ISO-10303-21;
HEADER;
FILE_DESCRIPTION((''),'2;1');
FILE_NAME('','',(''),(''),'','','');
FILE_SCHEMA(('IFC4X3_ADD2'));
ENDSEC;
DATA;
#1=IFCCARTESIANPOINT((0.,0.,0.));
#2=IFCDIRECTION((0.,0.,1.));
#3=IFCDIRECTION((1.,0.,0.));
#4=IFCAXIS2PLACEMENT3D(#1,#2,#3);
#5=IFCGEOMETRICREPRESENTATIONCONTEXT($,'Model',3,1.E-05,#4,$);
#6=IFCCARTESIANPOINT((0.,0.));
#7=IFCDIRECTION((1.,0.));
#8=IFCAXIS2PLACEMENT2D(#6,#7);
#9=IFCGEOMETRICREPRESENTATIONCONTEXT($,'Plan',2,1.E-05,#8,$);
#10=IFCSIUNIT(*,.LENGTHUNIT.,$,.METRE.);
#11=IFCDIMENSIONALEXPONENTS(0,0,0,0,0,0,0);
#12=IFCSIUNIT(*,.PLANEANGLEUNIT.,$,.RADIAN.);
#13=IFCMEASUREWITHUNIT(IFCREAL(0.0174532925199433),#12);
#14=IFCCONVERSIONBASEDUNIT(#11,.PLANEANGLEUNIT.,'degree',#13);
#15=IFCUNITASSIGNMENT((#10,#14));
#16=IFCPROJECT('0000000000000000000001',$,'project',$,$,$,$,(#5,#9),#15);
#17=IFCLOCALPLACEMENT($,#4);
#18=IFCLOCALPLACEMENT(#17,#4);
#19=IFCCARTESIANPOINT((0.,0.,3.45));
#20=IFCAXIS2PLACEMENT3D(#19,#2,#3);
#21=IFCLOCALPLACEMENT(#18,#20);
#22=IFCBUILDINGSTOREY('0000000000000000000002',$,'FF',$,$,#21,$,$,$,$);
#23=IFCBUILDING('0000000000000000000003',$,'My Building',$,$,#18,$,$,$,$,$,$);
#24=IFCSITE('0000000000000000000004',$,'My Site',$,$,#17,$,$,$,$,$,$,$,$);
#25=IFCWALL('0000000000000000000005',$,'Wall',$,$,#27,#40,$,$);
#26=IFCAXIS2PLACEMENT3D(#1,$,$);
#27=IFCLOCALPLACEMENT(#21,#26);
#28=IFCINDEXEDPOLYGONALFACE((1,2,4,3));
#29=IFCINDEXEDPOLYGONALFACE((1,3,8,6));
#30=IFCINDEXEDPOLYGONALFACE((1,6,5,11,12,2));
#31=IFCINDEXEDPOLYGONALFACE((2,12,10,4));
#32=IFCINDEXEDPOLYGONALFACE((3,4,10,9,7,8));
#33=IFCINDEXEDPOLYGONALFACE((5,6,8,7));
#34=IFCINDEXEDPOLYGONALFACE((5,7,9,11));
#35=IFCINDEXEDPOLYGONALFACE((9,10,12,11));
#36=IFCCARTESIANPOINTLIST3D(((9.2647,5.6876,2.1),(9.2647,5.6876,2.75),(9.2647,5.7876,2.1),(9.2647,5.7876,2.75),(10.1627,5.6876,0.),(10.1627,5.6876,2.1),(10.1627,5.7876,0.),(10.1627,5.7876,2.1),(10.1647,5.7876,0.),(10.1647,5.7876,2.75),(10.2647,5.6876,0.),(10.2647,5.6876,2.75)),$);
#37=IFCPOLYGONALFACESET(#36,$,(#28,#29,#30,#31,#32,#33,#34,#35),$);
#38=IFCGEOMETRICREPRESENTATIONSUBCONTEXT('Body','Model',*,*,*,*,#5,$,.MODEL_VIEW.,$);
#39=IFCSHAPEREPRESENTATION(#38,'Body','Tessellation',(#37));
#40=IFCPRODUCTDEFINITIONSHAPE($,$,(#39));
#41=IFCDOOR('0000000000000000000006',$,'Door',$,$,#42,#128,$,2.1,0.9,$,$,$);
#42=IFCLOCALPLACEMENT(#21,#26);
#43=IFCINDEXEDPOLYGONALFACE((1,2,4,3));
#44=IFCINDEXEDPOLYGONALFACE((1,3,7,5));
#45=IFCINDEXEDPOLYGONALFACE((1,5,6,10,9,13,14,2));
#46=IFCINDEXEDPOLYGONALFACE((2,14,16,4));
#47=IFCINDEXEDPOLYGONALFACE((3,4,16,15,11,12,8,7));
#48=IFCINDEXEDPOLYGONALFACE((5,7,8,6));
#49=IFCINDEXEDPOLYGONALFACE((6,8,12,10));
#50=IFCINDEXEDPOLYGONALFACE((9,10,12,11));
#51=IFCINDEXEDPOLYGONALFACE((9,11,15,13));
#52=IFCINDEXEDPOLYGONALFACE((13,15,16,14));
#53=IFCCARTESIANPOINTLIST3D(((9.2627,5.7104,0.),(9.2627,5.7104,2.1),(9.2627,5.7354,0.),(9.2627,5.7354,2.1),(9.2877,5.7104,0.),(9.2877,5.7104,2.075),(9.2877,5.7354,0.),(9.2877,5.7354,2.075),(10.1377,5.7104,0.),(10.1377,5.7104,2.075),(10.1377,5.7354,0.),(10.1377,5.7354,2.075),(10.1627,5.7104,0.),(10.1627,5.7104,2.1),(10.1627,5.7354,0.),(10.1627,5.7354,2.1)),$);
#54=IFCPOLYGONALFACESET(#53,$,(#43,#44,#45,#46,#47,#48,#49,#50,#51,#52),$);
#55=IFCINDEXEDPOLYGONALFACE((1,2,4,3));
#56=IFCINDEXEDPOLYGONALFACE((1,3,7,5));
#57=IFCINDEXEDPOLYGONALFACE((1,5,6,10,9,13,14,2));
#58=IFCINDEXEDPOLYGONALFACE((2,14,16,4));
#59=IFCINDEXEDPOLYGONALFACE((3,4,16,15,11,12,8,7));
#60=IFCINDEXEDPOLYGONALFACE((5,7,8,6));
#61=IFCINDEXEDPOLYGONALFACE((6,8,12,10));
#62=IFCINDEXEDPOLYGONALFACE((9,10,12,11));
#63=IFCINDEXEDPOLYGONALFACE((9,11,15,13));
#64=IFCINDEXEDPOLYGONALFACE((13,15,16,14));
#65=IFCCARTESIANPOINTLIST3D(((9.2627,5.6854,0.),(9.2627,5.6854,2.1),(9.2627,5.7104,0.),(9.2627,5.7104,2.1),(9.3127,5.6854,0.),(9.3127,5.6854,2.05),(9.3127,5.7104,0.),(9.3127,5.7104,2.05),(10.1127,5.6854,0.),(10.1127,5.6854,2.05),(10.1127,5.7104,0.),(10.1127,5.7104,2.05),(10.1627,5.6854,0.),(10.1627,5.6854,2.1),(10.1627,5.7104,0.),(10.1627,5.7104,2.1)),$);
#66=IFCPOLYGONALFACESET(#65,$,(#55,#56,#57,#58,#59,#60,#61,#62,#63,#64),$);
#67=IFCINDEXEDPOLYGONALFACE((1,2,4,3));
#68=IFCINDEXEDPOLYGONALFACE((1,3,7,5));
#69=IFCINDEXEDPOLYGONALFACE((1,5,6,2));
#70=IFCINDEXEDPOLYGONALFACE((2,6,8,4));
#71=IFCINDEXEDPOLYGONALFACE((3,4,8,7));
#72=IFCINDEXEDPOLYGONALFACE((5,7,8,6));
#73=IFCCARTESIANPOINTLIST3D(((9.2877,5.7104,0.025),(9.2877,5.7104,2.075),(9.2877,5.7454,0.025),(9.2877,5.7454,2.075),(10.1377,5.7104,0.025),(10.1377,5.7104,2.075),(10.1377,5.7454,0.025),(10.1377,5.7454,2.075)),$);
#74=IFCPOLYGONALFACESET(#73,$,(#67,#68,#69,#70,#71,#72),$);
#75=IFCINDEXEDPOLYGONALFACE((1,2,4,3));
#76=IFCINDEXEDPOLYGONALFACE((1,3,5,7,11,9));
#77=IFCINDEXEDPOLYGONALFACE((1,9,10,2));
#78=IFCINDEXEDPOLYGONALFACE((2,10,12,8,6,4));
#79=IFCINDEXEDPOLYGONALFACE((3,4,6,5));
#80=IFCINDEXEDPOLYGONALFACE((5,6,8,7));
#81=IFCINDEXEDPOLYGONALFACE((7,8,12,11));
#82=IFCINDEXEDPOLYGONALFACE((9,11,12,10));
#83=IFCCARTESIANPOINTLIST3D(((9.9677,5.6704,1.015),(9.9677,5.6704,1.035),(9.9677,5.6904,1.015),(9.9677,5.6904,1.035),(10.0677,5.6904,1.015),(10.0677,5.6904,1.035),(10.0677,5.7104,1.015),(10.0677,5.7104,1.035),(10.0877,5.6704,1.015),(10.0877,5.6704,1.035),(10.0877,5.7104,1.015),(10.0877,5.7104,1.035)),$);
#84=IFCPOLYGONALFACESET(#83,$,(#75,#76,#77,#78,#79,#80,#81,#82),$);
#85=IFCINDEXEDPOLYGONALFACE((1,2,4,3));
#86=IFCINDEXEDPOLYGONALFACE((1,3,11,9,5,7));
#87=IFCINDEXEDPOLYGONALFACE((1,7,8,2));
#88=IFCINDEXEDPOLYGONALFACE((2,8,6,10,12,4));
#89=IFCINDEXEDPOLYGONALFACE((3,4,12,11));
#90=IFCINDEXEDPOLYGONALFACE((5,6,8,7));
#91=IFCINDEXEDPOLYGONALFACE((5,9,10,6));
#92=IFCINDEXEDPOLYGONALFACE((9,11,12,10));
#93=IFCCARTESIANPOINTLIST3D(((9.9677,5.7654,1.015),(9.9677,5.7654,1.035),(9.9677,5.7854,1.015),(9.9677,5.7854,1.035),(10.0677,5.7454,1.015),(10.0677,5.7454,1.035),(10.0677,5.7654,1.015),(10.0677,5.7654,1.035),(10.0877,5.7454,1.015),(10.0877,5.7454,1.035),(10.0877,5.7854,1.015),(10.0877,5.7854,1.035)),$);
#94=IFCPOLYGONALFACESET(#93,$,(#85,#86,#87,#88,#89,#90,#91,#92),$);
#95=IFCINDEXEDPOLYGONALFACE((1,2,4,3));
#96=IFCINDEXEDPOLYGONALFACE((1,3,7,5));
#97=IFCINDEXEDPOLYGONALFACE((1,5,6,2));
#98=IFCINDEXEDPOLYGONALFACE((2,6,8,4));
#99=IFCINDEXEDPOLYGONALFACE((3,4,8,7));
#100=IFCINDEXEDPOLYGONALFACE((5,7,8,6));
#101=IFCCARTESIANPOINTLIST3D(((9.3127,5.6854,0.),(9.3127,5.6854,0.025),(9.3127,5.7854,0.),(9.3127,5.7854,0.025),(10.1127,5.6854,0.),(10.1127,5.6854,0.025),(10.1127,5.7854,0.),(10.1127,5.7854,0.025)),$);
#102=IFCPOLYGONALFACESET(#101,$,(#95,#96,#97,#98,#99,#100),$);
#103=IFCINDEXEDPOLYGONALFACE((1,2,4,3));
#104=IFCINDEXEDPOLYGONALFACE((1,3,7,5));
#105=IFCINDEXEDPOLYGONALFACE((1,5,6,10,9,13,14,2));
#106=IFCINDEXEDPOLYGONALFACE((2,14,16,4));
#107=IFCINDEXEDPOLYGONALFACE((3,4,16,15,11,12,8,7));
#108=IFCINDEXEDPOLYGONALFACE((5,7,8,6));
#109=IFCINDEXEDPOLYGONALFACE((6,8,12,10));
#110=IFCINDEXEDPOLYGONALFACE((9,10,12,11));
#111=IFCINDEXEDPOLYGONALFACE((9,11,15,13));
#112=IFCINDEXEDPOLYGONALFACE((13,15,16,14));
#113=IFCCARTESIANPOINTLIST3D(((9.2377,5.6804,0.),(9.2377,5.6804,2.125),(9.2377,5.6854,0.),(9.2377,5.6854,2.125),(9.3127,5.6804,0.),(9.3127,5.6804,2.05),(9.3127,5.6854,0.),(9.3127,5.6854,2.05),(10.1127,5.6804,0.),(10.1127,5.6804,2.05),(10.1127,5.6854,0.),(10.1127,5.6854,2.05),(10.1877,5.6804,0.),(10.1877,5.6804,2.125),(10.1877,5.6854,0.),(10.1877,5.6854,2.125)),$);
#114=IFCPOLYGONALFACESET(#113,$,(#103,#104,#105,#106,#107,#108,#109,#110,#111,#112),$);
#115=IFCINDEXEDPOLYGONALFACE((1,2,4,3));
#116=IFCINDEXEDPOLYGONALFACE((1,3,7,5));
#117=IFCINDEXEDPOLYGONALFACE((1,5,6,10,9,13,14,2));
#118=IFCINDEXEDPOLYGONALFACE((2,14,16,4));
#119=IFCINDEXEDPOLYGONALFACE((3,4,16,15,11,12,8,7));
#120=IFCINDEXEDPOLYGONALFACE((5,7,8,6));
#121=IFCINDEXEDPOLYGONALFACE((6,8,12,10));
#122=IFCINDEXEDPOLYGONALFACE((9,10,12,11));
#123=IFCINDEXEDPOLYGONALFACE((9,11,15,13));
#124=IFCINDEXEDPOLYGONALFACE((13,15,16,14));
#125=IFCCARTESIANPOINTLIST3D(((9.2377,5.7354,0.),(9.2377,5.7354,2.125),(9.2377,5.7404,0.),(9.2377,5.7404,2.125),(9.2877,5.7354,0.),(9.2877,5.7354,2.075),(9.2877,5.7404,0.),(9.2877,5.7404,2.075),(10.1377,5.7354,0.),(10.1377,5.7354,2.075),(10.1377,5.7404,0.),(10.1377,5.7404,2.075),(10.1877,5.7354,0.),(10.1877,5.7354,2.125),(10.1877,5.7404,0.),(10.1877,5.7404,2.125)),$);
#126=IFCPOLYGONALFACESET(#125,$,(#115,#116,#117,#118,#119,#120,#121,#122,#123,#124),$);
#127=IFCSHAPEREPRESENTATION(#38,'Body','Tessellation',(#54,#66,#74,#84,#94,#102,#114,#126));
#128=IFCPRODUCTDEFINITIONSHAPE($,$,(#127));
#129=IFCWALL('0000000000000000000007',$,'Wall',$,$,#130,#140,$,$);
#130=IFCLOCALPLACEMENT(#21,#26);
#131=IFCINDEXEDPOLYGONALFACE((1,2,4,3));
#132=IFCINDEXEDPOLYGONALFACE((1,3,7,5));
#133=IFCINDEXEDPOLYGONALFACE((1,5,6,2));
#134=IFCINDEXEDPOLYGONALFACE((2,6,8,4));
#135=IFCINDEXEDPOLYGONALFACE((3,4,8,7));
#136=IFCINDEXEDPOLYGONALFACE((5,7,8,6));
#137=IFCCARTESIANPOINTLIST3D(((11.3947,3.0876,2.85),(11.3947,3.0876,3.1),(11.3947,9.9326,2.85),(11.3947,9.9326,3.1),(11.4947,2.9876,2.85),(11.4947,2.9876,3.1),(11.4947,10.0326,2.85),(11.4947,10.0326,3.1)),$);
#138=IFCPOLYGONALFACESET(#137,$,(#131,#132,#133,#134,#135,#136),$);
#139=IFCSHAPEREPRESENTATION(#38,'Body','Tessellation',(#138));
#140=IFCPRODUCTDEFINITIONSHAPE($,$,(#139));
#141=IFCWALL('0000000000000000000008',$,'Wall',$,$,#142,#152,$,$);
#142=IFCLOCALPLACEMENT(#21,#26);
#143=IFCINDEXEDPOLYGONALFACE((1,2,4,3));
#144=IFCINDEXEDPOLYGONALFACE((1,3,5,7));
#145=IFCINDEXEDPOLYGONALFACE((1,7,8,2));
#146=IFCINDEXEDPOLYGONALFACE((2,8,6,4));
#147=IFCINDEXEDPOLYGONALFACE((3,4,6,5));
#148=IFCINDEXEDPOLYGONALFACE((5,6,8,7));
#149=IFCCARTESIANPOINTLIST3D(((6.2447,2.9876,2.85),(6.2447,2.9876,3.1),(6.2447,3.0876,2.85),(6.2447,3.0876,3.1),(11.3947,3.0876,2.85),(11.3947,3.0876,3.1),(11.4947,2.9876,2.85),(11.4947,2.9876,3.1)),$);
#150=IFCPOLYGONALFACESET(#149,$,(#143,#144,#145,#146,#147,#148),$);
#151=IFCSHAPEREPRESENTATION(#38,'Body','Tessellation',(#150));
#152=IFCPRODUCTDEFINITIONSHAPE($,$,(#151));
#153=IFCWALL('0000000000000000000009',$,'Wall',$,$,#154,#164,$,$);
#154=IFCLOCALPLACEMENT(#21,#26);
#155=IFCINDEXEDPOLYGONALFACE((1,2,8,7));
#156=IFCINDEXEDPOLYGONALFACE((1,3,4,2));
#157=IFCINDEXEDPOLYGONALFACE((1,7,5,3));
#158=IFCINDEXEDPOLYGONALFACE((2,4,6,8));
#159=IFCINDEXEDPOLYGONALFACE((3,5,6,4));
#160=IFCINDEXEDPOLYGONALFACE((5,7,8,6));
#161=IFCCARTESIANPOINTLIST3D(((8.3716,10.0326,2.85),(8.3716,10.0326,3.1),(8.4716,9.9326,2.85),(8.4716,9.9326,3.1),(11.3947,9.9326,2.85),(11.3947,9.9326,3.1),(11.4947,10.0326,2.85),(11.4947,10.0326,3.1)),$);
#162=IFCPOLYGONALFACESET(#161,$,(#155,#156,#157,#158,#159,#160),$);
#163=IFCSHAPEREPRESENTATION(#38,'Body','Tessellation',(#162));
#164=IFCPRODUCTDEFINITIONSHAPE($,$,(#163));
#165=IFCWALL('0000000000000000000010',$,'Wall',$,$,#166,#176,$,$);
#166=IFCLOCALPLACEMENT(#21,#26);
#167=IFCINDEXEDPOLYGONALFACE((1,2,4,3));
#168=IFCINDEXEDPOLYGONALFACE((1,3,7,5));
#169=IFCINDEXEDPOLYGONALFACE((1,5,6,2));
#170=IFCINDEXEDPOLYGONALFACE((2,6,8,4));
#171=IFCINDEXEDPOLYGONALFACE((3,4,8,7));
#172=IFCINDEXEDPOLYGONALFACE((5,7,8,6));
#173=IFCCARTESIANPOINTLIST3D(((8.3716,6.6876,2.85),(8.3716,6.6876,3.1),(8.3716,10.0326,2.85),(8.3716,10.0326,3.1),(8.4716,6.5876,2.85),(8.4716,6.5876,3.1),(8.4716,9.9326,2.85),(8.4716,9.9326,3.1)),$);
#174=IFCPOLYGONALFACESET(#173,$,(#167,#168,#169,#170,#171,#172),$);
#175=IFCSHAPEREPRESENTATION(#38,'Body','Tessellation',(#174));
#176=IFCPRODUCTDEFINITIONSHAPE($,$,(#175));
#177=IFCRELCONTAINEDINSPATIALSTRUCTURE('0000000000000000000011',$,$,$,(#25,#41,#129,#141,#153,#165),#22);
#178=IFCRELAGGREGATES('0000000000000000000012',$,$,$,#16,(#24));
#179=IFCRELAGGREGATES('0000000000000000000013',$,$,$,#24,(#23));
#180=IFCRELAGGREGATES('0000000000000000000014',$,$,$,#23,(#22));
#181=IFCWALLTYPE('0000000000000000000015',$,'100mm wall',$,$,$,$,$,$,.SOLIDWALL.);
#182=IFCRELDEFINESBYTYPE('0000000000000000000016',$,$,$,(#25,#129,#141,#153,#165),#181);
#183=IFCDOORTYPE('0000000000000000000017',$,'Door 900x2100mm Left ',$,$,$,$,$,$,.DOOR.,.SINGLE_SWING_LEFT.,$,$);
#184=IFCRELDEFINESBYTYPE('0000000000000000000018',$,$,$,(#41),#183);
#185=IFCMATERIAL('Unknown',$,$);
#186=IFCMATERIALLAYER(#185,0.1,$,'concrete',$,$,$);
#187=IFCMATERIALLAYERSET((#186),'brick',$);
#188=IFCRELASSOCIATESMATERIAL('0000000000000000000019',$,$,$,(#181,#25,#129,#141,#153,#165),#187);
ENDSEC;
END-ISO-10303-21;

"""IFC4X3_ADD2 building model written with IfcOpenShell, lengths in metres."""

from ifc_helpers import new_model, entity, si_unit, converted_unit, frame, origin_with_axes, origin_2d_with_axis, place, context, subcontext, project, spatial, line, indexed_curve, outline, extrude, shape, source, transform, mapped, material, layer, layer_set, layer_usage, type_object, type_shapes, element, fill, save


model = new_model("IFC4X3_ADD2")

# Units and contexts
model_context = context("Model", 3, precision=1e-05, world=origin_with_axes())
plan_context = context("Plan", 2, precision=1e-05, world=origin_2d_with_axis())
body_context_1 = subcontext(model_context, "Body", "Model", "MODEL_VIEW")
body_context_2 = subcontext(plan_context, "Body", "Plan", "PLAN_VIEW")
ifc_project = project(units=[si_unit("LENGTHUNIT", "METRE"), converted_unit("PLANEANGLEUNIT", "degree", entity("IfcReal", 0.0174532925199433), si_unit("PLANEANGLEUNIT", "RADIAN"), dimensions=[0, 0, 0, 0, 0, 0, 0])], contexts=[model_context, plan_context])

# Site, building, storey
site_placement = place(None, origin_with_axes())
site = spatial("IfcSite", under=ifc_project, at=site_placement, Name="My Site")
building_placement = place(site_placement, origin_with_axes())
building = spatial("IfcBuilding", under=site, at=building_placement, Name="My Building")
storey_placement = place(building_placement, frame((0.0, 0.0, 3.45), z_axis=(0.0, 0.0, 1.0), x_axis=(1.0, 0.0, 0.0)))
storey = spatial("IfcBuildingStorey", under=building, at=storey_placement, Name="FF")

# Shared definitions
ifc_material = material(Name="Unknown")

# Shared definitions
ifc_layer_1 = layer(ifc_material, 0.1, Name="concrete")
ifc_layer_set_1 = layer_set([ifc_layer_1], Name="brick")
wall_type_1 = type_object("IfcWallType", Name="100mm wall", PredefinedType="SOLIDWALL", material=ifc_layer_set_1)
shared_shape_1 = source(origin_with_axes(), body_context_1, "Body", "SweptSolid", [
    extrude(outline(indexed_curve([(0.0, 0.0), (0.9, 0.0), (0.9, 2.1), (0.0, 2.1)], segments=[line(1, 2, 3, 4, 1)])), frame((0.0, -0.6, 0.0), z_axis=(0.0, -1.0, 0.0), x_axis=(1.0, 0.0, 0.0)), (0.0, 0.0, -1.0), 1.2),
])
door_type_1 = type_object("IfcDoorType", Name="Door 900x2100mm Left ", OperationType="SINGLE_SWING_LEFT", PredefinedType="DOOR")
shared_shape_2 = source(origin_with_axes(), body_context_1, "Body", "SweptSolid", [
    extrude(outline(indexed_curve([(0.0, 0.0), (0.0, 2.1), (0.9, 2.1), (0.9, 0.0), (0.875, 0.0), (0.875, 2.075), (0.025, 2.075), (0.025, 0.0)], segments=[line(1, 2, 3, 4, 5, 6, 7, 8, 1)])), frame((0.0, 0.025, 0.0), z_axis=(0.0, -1.0, 0.0), x_axis=(1.0, 0.0, 0.0)), (0.0, 0.0, -1.0), 0.025),
    extrude(outline(indexed_curve([(0.0, 0.0), (0.0, 2.1), (0.9, 2.1), (0.9, 0.0), (0.85, 0.0), (0.85, 2.05), (0.05, 2.05), (0.05, 0.0)], segments=[line(1, 2, 3, 4, 5, 6, 7, 8, 1)])), frame((0.0, 0.0, 0.0), z_axis=(0.0, -1.0, 0.0), x_axis=(1.0, 0.0, 0.0)), (0.0, 0.0, -1.0), 0.025),
    extrude(outline(indexed_curve([(0.0, 0.0), (0.85, 0.0), (0.85, 0.035), (0.0, 0.035)], segments=[line(1, 2, 3, 4, 1)])), frame((0.025, 0.025, 0.025), z_axis=(0.0, 0.0, 1.0), x_axis=(1.0, 0.0, 0.0)), (0.0, 0.0, 1.0), 2.05),
    extrude(outline(indexed_curve([(0.0, 0.0), (0.0, -0.04), (-0.12, -0.04), (-0.12, -0.02), (-0.02, -0.02), (-0.02, 0.0)], segments=[line(1, 2, 3, 4, 5, 6, 1)])), frame((0.825, 0.025, 1.015), z_axis=(0.0, 0.0, 1.0), x_axis=(1.0, 0.0, 0.0)), (0.0, 0.0, 1.0), 0.02),
    extrude(outline(indexed_curve([(0.0, 0.0), (0.0, 0.04), (-0.12, 0.04), (-0.12, 0.02), (-0.02, 0.02), (-0.02, 0.0)], segments=[line(1, 2, 3, 4, 5, 6, 1)])), frame((0.825, 0.06, 1.015), z_axis=(0.0, 0.0, 1.0), x_axis=(1.0, 0.0, 0.0)), (0.0, 0.0, 1.0), 0.02),
    extrude(outline(indexed_curve([(0.0, 0.0), (0.8, 0.0), (0.8, 0.1), (0.0, 0.1)], segments=[line(1, 2, 3, 4, 1)])), frame((0.05, 0.0, 0.0), z_axis=(0.0, 0.0, 1.0), x_axis=(1.0, 0.0, 0.0)), (0.0, 0.0, 1.0), 0.025),
    extrude(outline(indexed_curve([(0.0, 0.0), (0.0, 2.125), (0.95, 2.125), (0.95, 0.0), (0.875, 0.0), (0.875, 2.05), (0.075, 2.05), (0.075, 0.0)], segments=[line(1, 2, 3, 4, 5, 6, 7, 8, 1)])), frame((-0.025, -0.005, 0.0), z_axis=(0.0, -1.0, 0.0), x_axis=(1.0, 0.0, 0.0)), (0.0, 0.0, -1.0), 0.005),
    extrude(outline(indexed_curve([(0.0, 0.0), (0.0, 2.125), (0.95, 2.125), (0.95, 0.0), (0.9, 0.0), (0.9, 2.075), (0.05, 2.075), (0.05, 0.0)], segments=[line(1, 2, 3, 4, 5, 6, 7, 8, 1)])), frame((-0.025, 0.05, 0.0), z_axis=(0.0, -1.0, 0.0), x_axis=(1.0, 0.0, 0.0)), (0.0, 0.0, -1.0), 0.005),
])
shared_shape_3 = source(origin_with_axes(), body_context_2, "Body", "Curve2D", [
    entity("IfcIndexedPolyCurve", entity("IfcCartesianPointList2D", [[0.0, 0.0], [0.0, 0.05], [0.025, 0.05], [0.025, 0.025], [0.05, 0.025], [0.05, 0.0]]), [entity("IfcLineIndex", [1, 2, 3, 4, 5, 6, 1])]),
    entity("IfcIndexedPolyCurve", entity("IfcCartesianPointList2D", [[0.9, 0.0], [0.9, 0.05], [0.875, 0.05], [0.875, 0.025], [0.85, 0.025], [0.85, 0.0]]), [entity("IfcLineIndex", [1, 2, 3, 4, 5, 6, 1])]),
    entity("IfcTrimmedCurve", entity("IfcEllipse", entity("IfcAxis2Placement2D", entity("IfcCartesianPoint", [0.06, 0.05]), entity("IfcDirection", [1.0, 0.0])), 0.815, 0.85), [entity("IfcCartesianPoint", [0.875, 0.05])], [entity("IfcCartesianPoint", [0.06, 0.9])], True, "CARTESIAN"),
    entity("IfcIndexedPolyCurve", entity("IfcCartesianPointList2D", [[0.025, 0.05], [0.06, 0.05], [0.06, 0.9], [0.025, 0.9]]), [entity("IfcLineIndex", [1, 2, 3, 4, 1])]),
])
type_shapes(door_type_1, [shared_shape_2, shared_shape_3])

# Wall, opening, door
ifc_layer_usage_1 = layer_usage(ifc_layer_set_1, "AXIS2", "POSITIVE", 0.0)
wall_1_placement = place(storey_placement, frame((10.2647, 5.7876, 0.0), z_axis=(0.0, 0.0, 1.0), x_axis=(-1.0, 0.0, 0.0)))
wall_1 = element("IfcWall", 1, at=wall_1_placement, inside=storey, type_object=wall_type_1, material=ifc_layer_usage_1, Name="Wall", context=body_context_1, shape_type="SweptSolid", body=[
    extrude(outline(indexed_curve([(0.1, 0.0), (0.0, 0.1), (1.0, 0.1), (1.0, 0.0)], segments=[line(1, 2, 3, 4, 1)])), origin_with_axes(), (0.0, 0.0, 1.0), 2.75),
])
opening_1_placement = place(wall_1_placement, frame((1.002, 0.1022, 0.0), z_axis=(0.0, 0.0, 1.0), x_axis=(-1.0, 0.0, 0.0)))
opening_1 = element("IfcOpeningElement", 2, at=opening_1_placement, cuts=wall_1, PredefinedType="OPENING", context=body_context_1, shape_type="MappedRepresentation", body=[
    mapped(shared_shape_1, transform((0.0, 0.0, 0.0), x_axis=(1.0, 0.0, 0.0), y_axis=(0.0, 1.0, 0.0), z_axis=(0.0, 0.0, 1.0), scale=1.0)),
])
door_1_placement = place(opening_1_placement, frame((0.0, 0.0, 0.0), z_axis=(0.0, 0.0, 1.0), x_axis=(1.0, 0.0, 0.0)))
door_1 = element("IfcDoor", 3, at=door_1_placement, inside=storey, type_object=door_type_1, Name="Door", OverallHeight=2.1, OverallWidth=0.9, shapes=[
    shape(body_context_1, "Body", "MappedRepresentation", [mapped(shared_shape_2, transform((0.0, 0.0, 0.0), x_axis=(1.0, 0.0, 0.0), y_axis=(0.0, 1.0, 0.0), z_axis=(0.0, 0.0, 1.0), scale=1.0))]),
    shape(body_context_2, "Body", "MappedRepresentation", [mapped(shared_shape_3, transform((0.0, 0.0, 0.0), x_axis=(1.0, 0.0, 0.0), y_axis=(0.0, 1.0, 0.0), z_axis=(0.0, 0.0, 1.0), scale=1.0))]),
])
fill(opening_1, door_1)

# Walls
ifc_layer_usage_2 = layer_usage(ifc_layer_set_1, "AXIS2", "POSITIVE", 0.0)
wall_2_placement = place(storey_placement, frame((11.4947, 3.0876, 2.85), z_axis=(0.0, 0.0, 1.0), x_axis=(0.0, 1.0, 0.0)))
element("IfcWall", 4, at=wall_2_placement, inside=storey, type_object=wall_type_1, material=ifc_layer_usage_2, Name="Wall", context=body_context_1, shape_type="SweptSolid", body=[
    extrude(outline(indexed_curve([(-0.1, 0.0), (0.0, 0.1), (6.845, 0.1), (6.945, 0.0)], segments=[line(1, 2, 3, 4, 1)])), origin_with_axes(), (0.0, 0.0, 1.0), 0.25),
])
ifc_layer_usage_3 = layer_usage(ifc_layer_set_1, "AXIS2", "POSITIVE", 0.0)
wall_3_placement = place(storey_placement, frame((11.4947, 3.0876, 2.85), z_axis=(0.0, 0.0, 1.0), x_axis=(-1.0, 0.0, 0.0)))
element("IfcWall", 5, at=wall_3_placement, inside=storey, type_object=wall_type_1, material=ifc_layer_usage_3, Name="Wall", context=body_context_1, shape_type="SweptSolid", body=[
    extrude(outline(indexed_curve([(0.1, 0.0), (0.0, 0.1), (5.25, 0.1), (5.25, 0.0)], segments=[line(1, 2, 3, 4, 1)])), origin_with_axes(), (0.0, 0.0, 1.0), 0.25),
])
ifc_layer_usage_4 = layer_usage(ifc_layer_set_1, "AXIS2", "POSITIVE", 0.0)
wall_4_placement = place(storey_placement, frame((11.4947, 10.0326, 2.85), z_axis=(0.0, 0.0, 1.0), x_axis=(-1.0, 0.0, 0.0)))
element("IfcWall", 6, at=wall_4_placement, inside=storey, type_object=wall_type_1, material=ifc_layer_usage_4, Name="Wall", context=body_context_1, shape_type="SweptSolid", body=[
    extrude(outline(indexed_curve([(0.0, 0.0), (0.1, 0.1), (3.023, 0.1), (3.123, 0.0)], segments=[line(1, 2, 3, 4, 1)])), origin_with_axes(), (0.0, 0.0, 1.0), 0.25),
])
ifc_layer_usage_5 = layer_usage(ifc_layer_set_1, "AXIS2", "POSITIVE", 0.0)
wall_5_placement = place(storey_placement, frame((8.3716, 10.0326, 2.85), z_axis=(0.0, 0.0, 1.0), x_axis=(-0.000001, -1.0, 0.0)))
element("IfcWall", 7, at=wall_5_placement, inside=storey, type_object=wall_type_1, material=ifc_layer_usage_5, Name="Wall", context=body_context_1, shape_type="SweptSolid", body=[
    extrude(outline(indexed_curve([(0.0, 0.0), (0.1, 0.1), (3.445, 0.1), (3.345, 0.0)], segments=[line(1, 2, 3, 4, 1)])), origin_with_axes(), (0.0, 0.0, 1.0), 0.25),
])

save(model, "model.ifc")
